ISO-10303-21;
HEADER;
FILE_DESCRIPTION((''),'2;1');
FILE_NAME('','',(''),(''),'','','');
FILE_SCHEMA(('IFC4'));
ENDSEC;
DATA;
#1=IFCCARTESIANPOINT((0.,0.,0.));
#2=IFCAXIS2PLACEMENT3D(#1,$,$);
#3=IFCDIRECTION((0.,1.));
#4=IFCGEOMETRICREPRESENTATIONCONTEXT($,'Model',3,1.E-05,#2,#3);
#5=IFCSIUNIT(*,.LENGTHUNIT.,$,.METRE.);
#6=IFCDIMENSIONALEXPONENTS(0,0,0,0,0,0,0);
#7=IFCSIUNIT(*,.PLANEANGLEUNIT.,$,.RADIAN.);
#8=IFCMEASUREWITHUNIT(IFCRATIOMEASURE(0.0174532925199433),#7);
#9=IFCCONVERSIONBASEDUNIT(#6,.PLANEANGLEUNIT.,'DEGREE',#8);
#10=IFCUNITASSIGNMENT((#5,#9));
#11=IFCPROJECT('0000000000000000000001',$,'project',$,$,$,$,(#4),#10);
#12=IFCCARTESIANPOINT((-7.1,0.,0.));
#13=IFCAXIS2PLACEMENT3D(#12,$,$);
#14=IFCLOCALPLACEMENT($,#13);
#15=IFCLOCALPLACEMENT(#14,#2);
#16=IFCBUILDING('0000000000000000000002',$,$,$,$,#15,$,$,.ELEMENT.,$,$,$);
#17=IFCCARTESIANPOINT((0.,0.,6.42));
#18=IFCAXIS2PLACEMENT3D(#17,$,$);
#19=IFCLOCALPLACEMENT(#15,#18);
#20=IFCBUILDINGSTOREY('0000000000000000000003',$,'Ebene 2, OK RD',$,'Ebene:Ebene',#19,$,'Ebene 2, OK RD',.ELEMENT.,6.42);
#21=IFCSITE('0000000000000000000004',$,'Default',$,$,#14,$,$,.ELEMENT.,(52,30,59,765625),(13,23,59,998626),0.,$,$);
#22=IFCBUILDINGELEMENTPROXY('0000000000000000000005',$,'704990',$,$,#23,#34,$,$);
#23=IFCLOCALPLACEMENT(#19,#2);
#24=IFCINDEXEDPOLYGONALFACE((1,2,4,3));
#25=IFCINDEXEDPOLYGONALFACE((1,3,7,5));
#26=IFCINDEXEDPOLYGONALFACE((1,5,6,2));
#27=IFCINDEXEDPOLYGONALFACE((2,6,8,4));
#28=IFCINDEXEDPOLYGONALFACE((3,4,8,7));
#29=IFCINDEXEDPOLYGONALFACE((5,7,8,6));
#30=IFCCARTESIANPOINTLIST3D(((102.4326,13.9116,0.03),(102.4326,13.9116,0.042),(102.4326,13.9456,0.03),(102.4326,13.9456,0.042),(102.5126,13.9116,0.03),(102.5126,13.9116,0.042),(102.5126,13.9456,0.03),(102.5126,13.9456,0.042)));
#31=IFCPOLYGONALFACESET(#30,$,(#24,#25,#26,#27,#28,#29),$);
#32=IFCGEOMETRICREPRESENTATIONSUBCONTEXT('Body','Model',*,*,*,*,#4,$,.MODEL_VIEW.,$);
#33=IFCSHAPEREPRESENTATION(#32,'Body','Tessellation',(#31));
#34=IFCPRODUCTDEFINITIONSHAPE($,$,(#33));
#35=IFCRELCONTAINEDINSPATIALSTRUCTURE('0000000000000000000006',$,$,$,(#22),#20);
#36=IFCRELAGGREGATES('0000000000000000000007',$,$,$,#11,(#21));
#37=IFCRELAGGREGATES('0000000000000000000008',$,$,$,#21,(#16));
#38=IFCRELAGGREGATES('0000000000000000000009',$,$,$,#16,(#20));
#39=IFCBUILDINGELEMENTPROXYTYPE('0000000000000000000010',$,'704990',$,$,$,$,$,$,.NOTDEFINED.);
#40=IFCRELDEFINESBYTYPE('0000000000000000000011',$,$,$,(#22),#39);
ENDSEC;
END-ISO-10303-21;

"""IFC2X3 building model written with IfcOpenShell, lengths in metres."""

from ifc_helpers import new_model, entity, si_unit, converted_unit, direction, frame, frame_2d, origin, place, context, subcontext, project, spatial, rectangle, extrude, type_object, element, save


model = new_model("IFC2X3")

# Units and contexts
model_context = context("Model", 3, precision=1e-05, world=origin(), true_north=direction((0.0, 1.0)))
body_context = subcontext(model_context, "Body", "Model", "MODEL_VIEW")
ifc_project = project(units=[si_unit("LENGTHUNIT", "METRE"), converted_unit("PLANEANGLEUNIT", "DEGREE", entity("IfcRatioMeasure", 0.0174532925199433), si_unit("PLANEANGLEUNIT", "RADIAN"), dimensions=[0, 0, 0, 0, 0, 0, 0])], contexts=[model_context])

# Site, building, storey
site_placement = place(None, frame((-7.1, 0.0, 0.0)))
site = spatial("IfcSite", under=ifc_project, at=site_placement, Name="Default", CompositionType="ELEMENT", RefLatitude=(52, 30, 59, 765625), RefLongitude=(13, 23, 59, 998626), RefElevation=0.0)
building_placement = place(site_placement, origin())
building = spatial("IfcBuilding", under=site, at=building_placement, CompositionType="ELEMENT")
storey_placement = place(building_placement, frame((0.0, 0.0, 6.42)))
storey = spatial("IfcBuildingStorey", under=building, at=storey_placement, Name="Ebene 2, OK RD", ObjectType="Ebene:Ebene", LongName="Ebene 2, OK RD", CompositionType="ELEMENT", Elevation=6.42)

# Building element proxy
building_element_proxy_type_1 = type_object("IfcBuildingElementProxyType", Name="704990", PredefinedType="NOTDEFINED")
proxy_1_placement = place(storey_placement, origin())
element("IfcBuildingElementProxy", 1, at=proxy_1_placement, inside=storey, type_object=building_element_proxy_type_1, Name="704990", context=body_context, shape_type="SweptSolid", body=[
    extrude(rectangle(XDim=0.08, YDim=0.034, at=frame_2d((0.0, 0.0), x_axis=(1.0, 0.0))), frame((102.4726, 13.9286, 0.03)), (0.0, 0.0, 1.0), 0.012),
])

save(model, "model.ifc")
